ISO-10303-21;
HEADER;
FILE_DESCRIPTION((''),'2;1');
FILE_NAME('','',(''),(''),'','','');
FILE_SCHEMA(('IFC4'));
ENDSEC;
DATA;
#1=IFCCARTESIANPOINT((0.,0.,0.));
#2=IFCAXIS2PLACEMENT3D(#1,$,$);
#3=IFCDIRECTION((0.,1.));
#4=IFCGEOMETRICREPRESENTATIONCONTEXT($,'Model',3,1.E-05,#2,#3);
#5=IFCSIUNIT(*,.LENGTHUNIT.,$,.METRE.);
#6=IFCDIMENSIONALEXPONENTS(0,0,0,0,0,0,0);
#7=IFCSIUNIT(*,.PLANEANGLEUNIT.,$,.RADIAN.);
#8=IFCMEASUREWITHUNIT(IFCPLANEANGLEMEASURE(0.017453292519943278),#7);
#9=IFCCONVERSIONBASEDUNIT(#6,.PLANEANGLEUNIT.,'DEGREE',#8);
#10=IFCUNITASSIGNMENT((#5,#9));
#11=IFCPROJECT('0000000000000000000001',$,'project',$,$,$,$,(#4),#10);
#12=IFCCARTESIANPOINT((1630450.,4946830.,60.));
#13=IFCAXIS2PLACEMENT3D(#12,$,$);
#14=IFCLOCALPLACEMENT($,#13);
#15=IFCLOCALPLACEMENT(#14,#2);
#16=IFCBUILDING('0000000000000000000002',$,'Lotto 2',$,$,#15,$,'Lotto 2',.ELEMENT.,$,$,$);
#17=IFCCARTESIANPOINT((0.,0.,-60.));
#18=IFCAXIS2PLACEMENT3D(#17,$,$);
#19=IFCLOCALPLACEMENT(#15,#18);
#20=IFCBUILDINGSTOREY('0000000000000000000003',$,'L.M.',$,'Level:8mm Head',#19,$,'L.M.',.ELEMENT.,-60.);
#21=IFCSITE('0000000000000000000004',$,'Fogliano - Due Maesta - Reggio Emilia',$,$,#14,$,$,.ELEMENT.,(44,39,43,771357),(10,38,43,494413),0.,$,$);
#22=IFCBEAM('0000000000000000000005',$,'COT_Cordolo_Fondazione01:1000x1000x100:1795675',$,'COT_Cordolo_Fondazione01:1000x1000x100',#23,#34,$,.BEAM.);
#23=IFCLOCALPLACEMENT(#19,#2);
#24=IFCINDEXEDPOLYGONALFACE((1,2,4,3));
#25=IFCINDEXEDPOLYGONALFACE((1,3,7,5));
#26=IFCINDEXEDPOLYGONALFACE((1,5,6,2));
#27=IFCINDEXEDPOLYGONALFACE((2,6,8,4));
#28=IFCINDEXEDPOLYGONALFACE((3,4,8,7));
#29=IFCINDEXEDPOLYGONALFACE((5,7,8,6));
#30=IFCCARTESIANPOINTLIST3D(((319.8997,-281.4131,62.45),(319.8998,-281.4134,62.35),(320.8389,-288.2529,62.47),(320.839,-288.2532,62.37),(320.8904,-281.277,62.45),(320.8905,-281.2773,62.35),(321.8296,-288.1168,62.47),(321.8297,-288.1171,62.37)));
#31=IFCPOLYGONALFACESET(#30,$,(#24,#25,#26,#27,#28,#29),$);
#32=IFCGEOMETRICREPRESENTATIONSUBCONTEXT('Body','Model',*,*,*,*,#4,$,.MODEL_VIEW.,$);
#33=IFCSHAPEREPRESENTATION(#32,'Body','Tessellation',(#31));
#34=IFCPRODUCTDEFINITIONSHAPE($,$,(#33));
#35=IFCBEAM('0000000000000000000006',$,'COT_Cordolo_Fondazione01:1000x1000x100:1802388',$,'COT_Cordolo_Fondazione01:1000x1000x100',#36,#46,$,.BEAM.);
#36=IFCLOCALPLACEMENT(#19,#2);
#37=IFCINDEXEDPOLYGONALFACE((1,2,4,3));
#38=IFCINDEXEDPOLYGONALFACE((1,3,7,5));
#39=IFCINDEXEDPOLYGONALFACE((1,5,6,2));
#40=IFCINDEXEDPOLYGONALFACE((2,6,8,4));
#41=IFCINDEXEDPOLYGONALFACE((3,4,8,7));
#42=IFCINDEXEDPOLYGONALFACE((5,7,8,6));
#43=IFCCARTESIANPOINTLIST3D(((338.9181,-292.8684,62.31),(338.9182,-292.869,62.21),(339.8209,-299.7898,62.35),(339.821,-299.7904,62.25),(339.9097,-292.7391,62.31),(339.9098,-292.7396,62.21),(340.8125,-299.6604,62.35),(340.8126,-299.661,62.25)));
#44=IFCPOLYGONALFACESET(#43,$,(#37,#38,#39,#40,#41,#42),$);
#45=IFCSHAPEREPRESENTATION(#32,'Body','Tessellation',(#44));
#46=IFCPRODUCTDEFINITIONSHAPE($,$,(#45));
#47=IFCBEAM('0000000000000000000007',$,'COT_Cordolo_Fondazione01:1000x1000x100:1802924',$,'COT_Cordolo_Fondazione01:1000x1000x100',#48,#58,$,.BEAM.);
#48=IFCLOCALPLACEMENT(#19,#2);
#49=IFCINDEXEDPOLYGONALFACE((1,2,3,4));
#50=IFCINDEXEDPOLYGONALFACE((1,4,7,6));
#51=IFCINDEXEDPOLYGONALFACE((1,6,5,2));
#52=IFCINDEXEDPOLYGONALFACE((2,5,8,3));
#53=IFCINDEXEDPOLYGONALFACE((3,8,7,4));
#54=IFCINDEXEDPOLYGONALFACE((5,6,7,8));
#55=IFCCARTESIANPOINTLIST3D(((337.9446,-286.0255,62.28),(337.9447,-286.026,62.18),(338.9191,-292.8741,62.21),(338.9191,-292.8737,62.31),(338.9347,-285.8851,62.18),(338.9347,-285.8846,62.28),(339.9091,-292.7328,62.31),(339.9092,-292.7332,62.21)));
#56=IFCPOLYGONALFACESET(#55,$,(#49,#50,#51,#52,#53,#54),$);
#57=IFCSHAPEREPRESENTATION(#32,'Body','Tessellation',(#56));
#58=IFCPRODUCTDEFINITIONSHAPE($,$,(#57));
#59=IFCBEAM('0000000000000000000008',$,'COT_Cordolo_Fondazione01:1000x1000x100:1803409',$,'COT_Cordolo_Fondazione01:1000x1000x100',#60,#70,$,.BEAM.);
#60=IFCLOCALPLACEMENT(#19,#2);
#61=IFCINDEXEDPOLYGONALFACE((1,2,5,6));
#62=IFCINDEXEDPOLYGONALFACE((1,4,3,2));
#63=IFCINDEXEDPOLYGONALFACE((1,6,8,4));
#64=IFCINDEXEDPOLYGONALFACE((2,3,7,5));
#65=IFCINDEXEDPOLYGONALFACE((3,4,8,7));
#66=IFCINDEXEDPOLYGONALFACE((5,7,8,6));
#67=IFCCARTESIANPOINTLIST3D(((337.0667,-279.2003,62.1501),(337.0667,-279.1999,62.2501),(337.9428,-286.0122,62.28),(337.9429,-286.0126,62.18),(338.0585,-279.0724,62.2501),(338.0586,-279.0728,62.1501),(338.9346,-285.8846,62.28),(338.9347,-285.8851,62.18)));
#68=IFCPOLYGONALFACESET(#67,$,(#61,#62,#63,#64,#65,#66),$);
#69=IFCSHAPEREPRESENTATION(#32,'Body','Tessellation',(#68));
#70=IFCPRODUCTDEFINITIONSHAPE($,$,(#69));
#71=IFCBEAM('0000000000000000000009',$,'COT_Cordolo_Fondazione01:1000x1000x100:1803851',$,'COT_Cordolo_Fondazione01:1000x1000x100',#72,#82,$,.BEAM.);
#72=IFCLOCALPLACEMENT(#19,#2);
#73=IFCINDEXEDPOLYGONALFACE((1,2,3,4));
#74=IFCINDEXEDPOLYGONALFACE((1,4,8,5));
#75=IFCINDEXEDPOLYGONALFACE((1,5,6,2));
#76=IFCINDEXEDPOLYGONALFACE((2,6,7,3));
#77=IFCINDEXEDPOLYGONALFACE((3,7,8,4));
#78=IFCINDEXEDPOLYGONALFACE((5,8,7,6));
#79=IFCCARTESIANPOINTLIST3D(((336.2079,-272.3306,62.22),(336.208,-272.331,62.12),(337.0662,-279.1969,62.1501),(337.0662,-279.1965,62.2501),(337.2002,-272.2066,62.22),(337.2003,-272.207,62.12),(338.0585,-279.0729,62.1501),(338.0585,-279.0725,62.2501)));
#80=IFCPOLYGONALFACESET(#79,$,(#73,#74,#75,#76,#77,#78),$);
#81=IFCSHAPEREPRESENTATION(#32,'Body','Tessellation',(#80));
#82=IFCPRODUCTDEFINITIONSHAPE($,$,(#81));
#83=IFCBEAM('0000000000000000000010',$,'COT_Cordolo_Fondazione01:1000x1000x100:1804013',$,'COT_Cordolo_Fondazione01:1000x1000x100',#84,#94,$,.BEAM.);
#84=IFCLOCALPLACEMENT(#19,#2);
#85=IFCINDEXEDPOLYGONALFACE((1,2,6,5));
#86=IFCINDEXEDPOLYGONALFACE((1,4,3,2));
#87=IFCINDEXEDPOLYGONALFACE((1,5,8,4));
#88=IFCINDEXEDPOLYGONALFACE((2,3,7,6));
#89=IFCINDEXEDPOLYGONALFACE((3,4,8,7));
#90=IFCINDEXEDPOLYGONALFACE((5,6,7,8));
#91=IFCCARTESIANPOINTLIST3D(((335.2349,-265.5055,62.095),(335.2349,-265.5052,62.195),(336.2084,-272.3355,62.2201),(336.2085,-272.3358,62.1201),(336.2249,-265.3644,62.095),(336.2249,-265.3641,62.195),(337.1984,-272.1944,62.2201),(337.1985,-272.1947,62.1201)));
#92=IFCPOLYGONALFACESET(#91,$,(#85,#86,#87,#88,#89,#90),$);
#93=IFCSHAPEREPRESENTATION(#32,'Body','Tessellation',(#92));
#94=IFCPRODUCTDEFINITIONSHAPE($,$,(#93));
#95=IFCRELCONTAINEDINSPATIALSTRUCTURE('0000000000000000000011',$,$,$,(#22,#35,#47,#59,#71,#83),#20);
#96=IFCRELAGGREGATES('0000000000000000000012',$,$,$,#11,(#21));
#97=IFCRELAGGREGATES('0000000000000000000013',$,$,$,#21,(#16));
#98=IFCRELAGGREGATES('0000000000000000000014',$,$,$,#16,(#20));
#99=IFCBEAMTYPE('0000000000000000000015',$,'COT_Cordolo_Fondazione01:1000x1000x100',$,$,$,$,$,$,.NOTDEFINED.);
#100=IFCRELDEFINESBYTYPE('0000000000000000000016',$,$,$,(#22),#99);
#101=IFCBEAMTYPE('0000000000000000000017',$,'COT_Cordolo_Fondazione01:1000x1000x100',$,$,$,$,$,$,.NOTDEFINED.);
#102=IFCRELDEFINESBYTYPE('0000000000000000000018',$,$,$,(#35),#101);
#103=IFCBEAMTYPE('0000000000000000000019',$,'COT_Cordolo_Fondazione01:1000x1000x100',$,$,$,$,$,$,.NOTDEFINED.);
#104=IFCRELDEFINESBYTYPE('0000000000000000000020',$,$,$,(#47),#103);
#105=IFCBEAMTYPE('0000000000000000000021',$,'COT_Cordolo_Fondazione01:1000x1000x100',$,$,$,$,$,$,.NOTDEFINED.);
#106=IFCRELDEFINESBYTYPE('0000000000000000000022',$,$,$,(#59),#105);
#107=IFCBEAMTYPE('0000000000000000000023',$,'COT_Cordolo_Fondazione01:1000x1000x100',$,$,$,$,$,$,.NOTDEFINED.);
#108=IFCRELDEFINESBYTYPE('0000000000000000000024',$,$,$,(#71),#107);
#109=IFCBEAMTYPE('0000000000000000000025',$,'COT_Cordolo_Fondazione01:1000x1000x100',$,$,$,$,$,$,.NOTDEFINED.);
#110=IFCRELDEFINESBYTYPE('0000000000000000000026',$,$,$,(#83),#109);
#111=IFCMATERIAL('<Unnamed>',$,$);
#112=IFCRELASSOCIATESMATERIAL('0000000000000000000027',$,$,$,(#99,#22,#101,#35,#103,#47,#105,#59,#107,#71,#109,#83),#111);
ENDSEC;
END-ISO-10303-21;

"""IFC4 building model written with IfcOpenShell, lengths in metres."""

from ifc_helpers import new_model, entity, si_unit, converted_unit, direction, frame, origin, place, context, subcontext, project, spatial, indexed_curve, outline, extrude, source, transform, mapped, material, type_object, type_shapes, element, save


model = new_model("IFC4")

# Units and contexts
model_context = context("Model", 3, precision=1e-05, world=origin(), true_north=direction((0.0, 1.0)))
body_context = subcontext(model_context, "Body", "Model", "MODEL_VIEW")
ifc_project = project(units=[si_unit("LENGTHUNIT", "METRE"), converted_unit("PLANEANGLEUNIT", "DEGREE", entity("IfcPlaneAngleMeasure", 0.017453292519943278), si_unit("PLANEANGLEUNIT", "RADIAN"), dimensions=[0, 0, 0, 0, 0, 0, 0])], contexts=[model_context])

# Site, building, storey
site_placement = place(None, frame((1630450.0, 4946830.0, 60.0)))
site = spatial("IfcSite", under=ifc_project, at=site_placement, Name="Fogliano - Due Maesta - Reggio Emilia", CompositionType="ELEMENT", RefLatitude=(44, 39, 43, 771357), RefLongitude=(10, 38, 43, 494413), RefElevation=0.0)
building_placement = place(site_placement, origin())
building = spatial("IfcBuilding", under=site, at=building_placement, Name="Lotto 2", LongName="Lotto 2", CompositionType="ELEMENT")
storey_placement = place(building_placement, frame((0.0, 0.0, -60.0)))
storey = spatial("IfcBuildingStorey", under=building, at=storey_placement, Name="L.M.", ObjectType="Level:8mm Head", LongName="L.M.", CompositionType="ELEMENT", Elevation=-60.0)

# Beams
ifc_material_1 = material(Name="<Unnamed>")
beam_type_1 = type_object("IfcBeamType", Name="COT_Cordolo_Fondazione01:1000x1000x100", PredefinedType="NOTDEFINED", material=ifc_material_1)
shared_shape_1 = source(origin(), body_context, "Body", "SweptSolid", [
    extrude(outline(indexed_curve([(-3.452, -0.5), (3.452, -0.5), (3.452, 0.5), (-3.452, 0.5), (-3.452, -0.5)], self_intersect=False)), frame((-0.002, 0.0, -0.05), z_axis=(0.0, 0.0, 1.0), x_axis=(-1.0, 0.0, 0.0)), (0.0, 0.0, 1.0), 0.1),
])
type_shapes(beam_type_1, [shared_shape_1])
beam_1_placement = place(storey_placement, frame((320.8644, -284.7631, 62.41), z_axis=(-0.000394, 0.002872, 0.999996), x_axis=(-0.13604, 0.990699, -0.002899)))
element("IfcBeam", 1, at=beam_1_placement, inside=storey, type_object=beam_type_1, material=ifc_material_1, Name="COT_Cordolo_Fondazione01:1000x1000x100:1795675", ObjectType="COT_Cordolo_Fondazione01:1000x1000x100", PredefinedType="BEAM", context=body_context, shape_type="MappedRepresentation", body=[
    mapped(shared_shape_1, transform((0.0, 0.0, 0.0), scale=1.0)),
])
beam_type_2 = type_object("IfcBeamType", Name="COT_Cordolo_Fondazione01:1000x1000x100", PredefinedType="NOTDEFINED", material=ifc_material_1)
shared_shape_2 = source(origin(), body_context, "Body", "SweptSolid", [
    extrude(outline(indexed_curve([(-3.4901, -0.5), (3.4901, -0.5), (3.4901, 0.5), (-3.4901, 0.5), (-3.4901, -0.5)], self_intersect=False)), frame((0.0, 0.0, -0.05), z_axis=(0.0, 0.0, 1.0), x_axis=(-1.0, 0.0, 0.0)), (0.0, 0.0, 1.0), 0.1),
])
type_shapes(beam_type_2, [shared_shape_2])
beam_2_placement = place(storey_placement, frame((339.8653, -296.2647, 62.28), z_axis=(-0.000741, 0.005682, 0.999984), x_axis=(-0.129337, 0.991584, -0.005731)))
element("IfcBeam", 2, at=beam_2_placement, inside=storey, type_object=beam_type_2, material=ifc_material_1, Name="COT_Cordolo_Fondazione01:1000x1000x100:1802388", ObjectType="COT_Cordolo_Fondazione01:1000x1000x100", PredefinedType="BEAM", context=body_context, shape_type="MappedRepresentation", body=[
    mapped(shared_shape_2, transform((0.0, 0.0, 0.0), scale=1.0)),
])
beam_type_3 = type_object("IfcBeamType", Name="COT_Cordolo_Fondazione01:1000x1000x100", PredefinedType="NOTDEFINED", material=ifc_material_1)
shared_shape_3 = source(origin(), body_context, "Body", "SweptSolid", [
    extrude(outline(indexed_curve([(-3.4586, -0.5), (3.4586, -0.5), (3.4586, 0.5), (-3.4586, 0.5), (-3.4586, -0.5)], self_intersect=False)), frame((-0.0014, 0.0, -0.05), z_axis=(0.0, 0.0, 1.0), x_axis=(-1.0, 0.0, 0.0)), (0.0, 0.0, 1.0), 0.1),
])
type_shapes(beam_type_3, [shared_shape_3])
beam_3_placement = place(storey_placement, frame((338.9267, -289.3779, 62.245), z_axis=(-0.000611, 0.004292, 0.999991), x_axis=(-0.140874, 0.990018, -0.004335)))
element("IfcBeam", 3, at=beam_3_placement, inside=storey, type_object=beam_type_3, material=ifc_material_1, Name="COT_Cordolo_Fondazione01:1000x1000x100:1802924", ObjectType="COT_Cordolo_Fondazione01:1000x1000x100", PredefinedType="BEAM", context=body_context, shape_type="MappedRepresentation", body=[
    mapped(shared_shape_3, transform((0.0, 0.0, 0.0), scale=1.0)),
])
beam_type_4 = type_object("IfcBeamType", Name="COT_Cordolo_Fondazione01:1000x1000x100", PredefinedType="NOTDEFINED", material=ifc_material_1)
shared_shape_4 = source(origin(), body_context, "Body", "SweptSolid", [
    extrude(outline(indexed_curve([(-3.4342, -0.5), (3.4342, -0.5), (3.4342, 0.5), (-3.4342, 0.5), (-3.4342, -0.5)], self_intersect=False)), frame((-0.0054, 0.0, -0.05), z_axis=(0.0, 0.0, 1.0), x_axis=(-1.0, 0.0, 0.0)), (0.0, 0.0, 1.0), 0.1),
])
type_shapes(beam_type_4, [shared_shape_4])
beam_4_placement = place(storey_placement, frame((338.0, -282.5371, 62.215), z_axis=(-0.000556, 0.004325, 0.99999), x_axis=(-0.127557, 0.991822, -0.00436)))
element("IfcBeam", 4, at=beam_4_placement, inside=storey, type_object=beam_type_4, material=ifc_material_1, Name="COT_Cordolo_Fondazione01:1000x1000x100:1803409", ObjectType="COT_Cordolo_Fondazione01:1000x1000x100", PredefinedType="BEAM", context=body_context, shape_type="MappedRepresentation", body=[
    mapped(shared_shape_4, transform((0.0, 0.0, 0.0), scale=1.0)),
])
beam_type_5 = type_object("IfcBeamType", Name="COT_Cordolo_Fondazione01:1000x1000x100", PredefinedType="NOTDEFINED", material=ifc_material_1)
shared_shape_5 = source(origin(), body_context, "Body", "SweptSolid", [
    extrude(outline(indexed_curve([(-3.4597, -0.5), (3.4597, -0.5), (3.4597, 0.5), (-3.4597, 0.5), (-3.4597, -0.5)], self_intersect=False)), frame((-0.0077, 0.0, -0.05), z_axis=(0.0, 0.0, 1.0), x_axis=(-1.0, 0.0, 0.0)), (0.0, 0.0, 1.0), 0.1),
])
type_shapes(beam_type_5, [shared_shape_5])
beam_5_placement = place(storey_placement, frame((337.1323, -275.6941, 62.185), z_axis=(-0.000539, 0.004314, 0.999991), x_axis=(-0.124034, 0.992268, -0.004348)))
element("IfcBeam", 5, at=beam_5_placement, inside=storey, type_object=beam_type_5, material=ifc_material_1, Name="COT_Cordolo_Fondazione01:1000x1000x100:1803851", ObjectType="COT_Cordolo_Fondazione01:1000x1000x100", PredefinedType="BEAM", context=body_context, shape_type="MappedRepresentation", body=[
    mapped(shared_shape_5, transform((0.0, 0.0, 0.0), scale=1.0)),
])
beam_type_6 = type_object("IfcBeamType", Name="COT_Cordolo_Fondazione01:1000x1000x100", PredefinedType="NOTDEFINED", material=ifc_material_1)
shared_shape_6 = source(origin(), body_context, "Body", "SweptSolid", [
    extrude(outline(indexed_curve([(-3.4497, -0.5), (3.4497, -0.5), (3.4497, 0.5), (-3.4497, 0.5), (-3.4497, -0.5)], self_intersect=False)), frame((-0.0077, 0.0, -0.05), z_axis=(0.0, 0.0, 1.0), x_axis=(-1.0, 0.0, 0.0)), (0.0, 0.0, 1.0), 0.1),
])
type_shapes(beam_type_6, [shared_shape_6])
beam_6_placement = place(storey_placement, frame((336.2156, -268.8423, 62.1575), z_axis=(-0.000513, 0.003597, 0.999993), x_axis=(-0.141112, 0.989987, -0.003634)))
element("IfcBeam", 6, at=beam_6_placement, inside=storey, type_object=beam_type_6, material=ifc_material_1, Name="COT_Cordolo_Fondazione01:1000x1000x100:1804013", ObjectType="COT_Cordolo_Fondazione01:1000x1000x100", PredefinedType="BEAM", context=body_context, shape_type="MappedRepresentation", body=[
    mapped(shared_shape_6, transform((0.0, 0.0, 0.0), scale=1.0)),
])

save(model, "model.ifc")
